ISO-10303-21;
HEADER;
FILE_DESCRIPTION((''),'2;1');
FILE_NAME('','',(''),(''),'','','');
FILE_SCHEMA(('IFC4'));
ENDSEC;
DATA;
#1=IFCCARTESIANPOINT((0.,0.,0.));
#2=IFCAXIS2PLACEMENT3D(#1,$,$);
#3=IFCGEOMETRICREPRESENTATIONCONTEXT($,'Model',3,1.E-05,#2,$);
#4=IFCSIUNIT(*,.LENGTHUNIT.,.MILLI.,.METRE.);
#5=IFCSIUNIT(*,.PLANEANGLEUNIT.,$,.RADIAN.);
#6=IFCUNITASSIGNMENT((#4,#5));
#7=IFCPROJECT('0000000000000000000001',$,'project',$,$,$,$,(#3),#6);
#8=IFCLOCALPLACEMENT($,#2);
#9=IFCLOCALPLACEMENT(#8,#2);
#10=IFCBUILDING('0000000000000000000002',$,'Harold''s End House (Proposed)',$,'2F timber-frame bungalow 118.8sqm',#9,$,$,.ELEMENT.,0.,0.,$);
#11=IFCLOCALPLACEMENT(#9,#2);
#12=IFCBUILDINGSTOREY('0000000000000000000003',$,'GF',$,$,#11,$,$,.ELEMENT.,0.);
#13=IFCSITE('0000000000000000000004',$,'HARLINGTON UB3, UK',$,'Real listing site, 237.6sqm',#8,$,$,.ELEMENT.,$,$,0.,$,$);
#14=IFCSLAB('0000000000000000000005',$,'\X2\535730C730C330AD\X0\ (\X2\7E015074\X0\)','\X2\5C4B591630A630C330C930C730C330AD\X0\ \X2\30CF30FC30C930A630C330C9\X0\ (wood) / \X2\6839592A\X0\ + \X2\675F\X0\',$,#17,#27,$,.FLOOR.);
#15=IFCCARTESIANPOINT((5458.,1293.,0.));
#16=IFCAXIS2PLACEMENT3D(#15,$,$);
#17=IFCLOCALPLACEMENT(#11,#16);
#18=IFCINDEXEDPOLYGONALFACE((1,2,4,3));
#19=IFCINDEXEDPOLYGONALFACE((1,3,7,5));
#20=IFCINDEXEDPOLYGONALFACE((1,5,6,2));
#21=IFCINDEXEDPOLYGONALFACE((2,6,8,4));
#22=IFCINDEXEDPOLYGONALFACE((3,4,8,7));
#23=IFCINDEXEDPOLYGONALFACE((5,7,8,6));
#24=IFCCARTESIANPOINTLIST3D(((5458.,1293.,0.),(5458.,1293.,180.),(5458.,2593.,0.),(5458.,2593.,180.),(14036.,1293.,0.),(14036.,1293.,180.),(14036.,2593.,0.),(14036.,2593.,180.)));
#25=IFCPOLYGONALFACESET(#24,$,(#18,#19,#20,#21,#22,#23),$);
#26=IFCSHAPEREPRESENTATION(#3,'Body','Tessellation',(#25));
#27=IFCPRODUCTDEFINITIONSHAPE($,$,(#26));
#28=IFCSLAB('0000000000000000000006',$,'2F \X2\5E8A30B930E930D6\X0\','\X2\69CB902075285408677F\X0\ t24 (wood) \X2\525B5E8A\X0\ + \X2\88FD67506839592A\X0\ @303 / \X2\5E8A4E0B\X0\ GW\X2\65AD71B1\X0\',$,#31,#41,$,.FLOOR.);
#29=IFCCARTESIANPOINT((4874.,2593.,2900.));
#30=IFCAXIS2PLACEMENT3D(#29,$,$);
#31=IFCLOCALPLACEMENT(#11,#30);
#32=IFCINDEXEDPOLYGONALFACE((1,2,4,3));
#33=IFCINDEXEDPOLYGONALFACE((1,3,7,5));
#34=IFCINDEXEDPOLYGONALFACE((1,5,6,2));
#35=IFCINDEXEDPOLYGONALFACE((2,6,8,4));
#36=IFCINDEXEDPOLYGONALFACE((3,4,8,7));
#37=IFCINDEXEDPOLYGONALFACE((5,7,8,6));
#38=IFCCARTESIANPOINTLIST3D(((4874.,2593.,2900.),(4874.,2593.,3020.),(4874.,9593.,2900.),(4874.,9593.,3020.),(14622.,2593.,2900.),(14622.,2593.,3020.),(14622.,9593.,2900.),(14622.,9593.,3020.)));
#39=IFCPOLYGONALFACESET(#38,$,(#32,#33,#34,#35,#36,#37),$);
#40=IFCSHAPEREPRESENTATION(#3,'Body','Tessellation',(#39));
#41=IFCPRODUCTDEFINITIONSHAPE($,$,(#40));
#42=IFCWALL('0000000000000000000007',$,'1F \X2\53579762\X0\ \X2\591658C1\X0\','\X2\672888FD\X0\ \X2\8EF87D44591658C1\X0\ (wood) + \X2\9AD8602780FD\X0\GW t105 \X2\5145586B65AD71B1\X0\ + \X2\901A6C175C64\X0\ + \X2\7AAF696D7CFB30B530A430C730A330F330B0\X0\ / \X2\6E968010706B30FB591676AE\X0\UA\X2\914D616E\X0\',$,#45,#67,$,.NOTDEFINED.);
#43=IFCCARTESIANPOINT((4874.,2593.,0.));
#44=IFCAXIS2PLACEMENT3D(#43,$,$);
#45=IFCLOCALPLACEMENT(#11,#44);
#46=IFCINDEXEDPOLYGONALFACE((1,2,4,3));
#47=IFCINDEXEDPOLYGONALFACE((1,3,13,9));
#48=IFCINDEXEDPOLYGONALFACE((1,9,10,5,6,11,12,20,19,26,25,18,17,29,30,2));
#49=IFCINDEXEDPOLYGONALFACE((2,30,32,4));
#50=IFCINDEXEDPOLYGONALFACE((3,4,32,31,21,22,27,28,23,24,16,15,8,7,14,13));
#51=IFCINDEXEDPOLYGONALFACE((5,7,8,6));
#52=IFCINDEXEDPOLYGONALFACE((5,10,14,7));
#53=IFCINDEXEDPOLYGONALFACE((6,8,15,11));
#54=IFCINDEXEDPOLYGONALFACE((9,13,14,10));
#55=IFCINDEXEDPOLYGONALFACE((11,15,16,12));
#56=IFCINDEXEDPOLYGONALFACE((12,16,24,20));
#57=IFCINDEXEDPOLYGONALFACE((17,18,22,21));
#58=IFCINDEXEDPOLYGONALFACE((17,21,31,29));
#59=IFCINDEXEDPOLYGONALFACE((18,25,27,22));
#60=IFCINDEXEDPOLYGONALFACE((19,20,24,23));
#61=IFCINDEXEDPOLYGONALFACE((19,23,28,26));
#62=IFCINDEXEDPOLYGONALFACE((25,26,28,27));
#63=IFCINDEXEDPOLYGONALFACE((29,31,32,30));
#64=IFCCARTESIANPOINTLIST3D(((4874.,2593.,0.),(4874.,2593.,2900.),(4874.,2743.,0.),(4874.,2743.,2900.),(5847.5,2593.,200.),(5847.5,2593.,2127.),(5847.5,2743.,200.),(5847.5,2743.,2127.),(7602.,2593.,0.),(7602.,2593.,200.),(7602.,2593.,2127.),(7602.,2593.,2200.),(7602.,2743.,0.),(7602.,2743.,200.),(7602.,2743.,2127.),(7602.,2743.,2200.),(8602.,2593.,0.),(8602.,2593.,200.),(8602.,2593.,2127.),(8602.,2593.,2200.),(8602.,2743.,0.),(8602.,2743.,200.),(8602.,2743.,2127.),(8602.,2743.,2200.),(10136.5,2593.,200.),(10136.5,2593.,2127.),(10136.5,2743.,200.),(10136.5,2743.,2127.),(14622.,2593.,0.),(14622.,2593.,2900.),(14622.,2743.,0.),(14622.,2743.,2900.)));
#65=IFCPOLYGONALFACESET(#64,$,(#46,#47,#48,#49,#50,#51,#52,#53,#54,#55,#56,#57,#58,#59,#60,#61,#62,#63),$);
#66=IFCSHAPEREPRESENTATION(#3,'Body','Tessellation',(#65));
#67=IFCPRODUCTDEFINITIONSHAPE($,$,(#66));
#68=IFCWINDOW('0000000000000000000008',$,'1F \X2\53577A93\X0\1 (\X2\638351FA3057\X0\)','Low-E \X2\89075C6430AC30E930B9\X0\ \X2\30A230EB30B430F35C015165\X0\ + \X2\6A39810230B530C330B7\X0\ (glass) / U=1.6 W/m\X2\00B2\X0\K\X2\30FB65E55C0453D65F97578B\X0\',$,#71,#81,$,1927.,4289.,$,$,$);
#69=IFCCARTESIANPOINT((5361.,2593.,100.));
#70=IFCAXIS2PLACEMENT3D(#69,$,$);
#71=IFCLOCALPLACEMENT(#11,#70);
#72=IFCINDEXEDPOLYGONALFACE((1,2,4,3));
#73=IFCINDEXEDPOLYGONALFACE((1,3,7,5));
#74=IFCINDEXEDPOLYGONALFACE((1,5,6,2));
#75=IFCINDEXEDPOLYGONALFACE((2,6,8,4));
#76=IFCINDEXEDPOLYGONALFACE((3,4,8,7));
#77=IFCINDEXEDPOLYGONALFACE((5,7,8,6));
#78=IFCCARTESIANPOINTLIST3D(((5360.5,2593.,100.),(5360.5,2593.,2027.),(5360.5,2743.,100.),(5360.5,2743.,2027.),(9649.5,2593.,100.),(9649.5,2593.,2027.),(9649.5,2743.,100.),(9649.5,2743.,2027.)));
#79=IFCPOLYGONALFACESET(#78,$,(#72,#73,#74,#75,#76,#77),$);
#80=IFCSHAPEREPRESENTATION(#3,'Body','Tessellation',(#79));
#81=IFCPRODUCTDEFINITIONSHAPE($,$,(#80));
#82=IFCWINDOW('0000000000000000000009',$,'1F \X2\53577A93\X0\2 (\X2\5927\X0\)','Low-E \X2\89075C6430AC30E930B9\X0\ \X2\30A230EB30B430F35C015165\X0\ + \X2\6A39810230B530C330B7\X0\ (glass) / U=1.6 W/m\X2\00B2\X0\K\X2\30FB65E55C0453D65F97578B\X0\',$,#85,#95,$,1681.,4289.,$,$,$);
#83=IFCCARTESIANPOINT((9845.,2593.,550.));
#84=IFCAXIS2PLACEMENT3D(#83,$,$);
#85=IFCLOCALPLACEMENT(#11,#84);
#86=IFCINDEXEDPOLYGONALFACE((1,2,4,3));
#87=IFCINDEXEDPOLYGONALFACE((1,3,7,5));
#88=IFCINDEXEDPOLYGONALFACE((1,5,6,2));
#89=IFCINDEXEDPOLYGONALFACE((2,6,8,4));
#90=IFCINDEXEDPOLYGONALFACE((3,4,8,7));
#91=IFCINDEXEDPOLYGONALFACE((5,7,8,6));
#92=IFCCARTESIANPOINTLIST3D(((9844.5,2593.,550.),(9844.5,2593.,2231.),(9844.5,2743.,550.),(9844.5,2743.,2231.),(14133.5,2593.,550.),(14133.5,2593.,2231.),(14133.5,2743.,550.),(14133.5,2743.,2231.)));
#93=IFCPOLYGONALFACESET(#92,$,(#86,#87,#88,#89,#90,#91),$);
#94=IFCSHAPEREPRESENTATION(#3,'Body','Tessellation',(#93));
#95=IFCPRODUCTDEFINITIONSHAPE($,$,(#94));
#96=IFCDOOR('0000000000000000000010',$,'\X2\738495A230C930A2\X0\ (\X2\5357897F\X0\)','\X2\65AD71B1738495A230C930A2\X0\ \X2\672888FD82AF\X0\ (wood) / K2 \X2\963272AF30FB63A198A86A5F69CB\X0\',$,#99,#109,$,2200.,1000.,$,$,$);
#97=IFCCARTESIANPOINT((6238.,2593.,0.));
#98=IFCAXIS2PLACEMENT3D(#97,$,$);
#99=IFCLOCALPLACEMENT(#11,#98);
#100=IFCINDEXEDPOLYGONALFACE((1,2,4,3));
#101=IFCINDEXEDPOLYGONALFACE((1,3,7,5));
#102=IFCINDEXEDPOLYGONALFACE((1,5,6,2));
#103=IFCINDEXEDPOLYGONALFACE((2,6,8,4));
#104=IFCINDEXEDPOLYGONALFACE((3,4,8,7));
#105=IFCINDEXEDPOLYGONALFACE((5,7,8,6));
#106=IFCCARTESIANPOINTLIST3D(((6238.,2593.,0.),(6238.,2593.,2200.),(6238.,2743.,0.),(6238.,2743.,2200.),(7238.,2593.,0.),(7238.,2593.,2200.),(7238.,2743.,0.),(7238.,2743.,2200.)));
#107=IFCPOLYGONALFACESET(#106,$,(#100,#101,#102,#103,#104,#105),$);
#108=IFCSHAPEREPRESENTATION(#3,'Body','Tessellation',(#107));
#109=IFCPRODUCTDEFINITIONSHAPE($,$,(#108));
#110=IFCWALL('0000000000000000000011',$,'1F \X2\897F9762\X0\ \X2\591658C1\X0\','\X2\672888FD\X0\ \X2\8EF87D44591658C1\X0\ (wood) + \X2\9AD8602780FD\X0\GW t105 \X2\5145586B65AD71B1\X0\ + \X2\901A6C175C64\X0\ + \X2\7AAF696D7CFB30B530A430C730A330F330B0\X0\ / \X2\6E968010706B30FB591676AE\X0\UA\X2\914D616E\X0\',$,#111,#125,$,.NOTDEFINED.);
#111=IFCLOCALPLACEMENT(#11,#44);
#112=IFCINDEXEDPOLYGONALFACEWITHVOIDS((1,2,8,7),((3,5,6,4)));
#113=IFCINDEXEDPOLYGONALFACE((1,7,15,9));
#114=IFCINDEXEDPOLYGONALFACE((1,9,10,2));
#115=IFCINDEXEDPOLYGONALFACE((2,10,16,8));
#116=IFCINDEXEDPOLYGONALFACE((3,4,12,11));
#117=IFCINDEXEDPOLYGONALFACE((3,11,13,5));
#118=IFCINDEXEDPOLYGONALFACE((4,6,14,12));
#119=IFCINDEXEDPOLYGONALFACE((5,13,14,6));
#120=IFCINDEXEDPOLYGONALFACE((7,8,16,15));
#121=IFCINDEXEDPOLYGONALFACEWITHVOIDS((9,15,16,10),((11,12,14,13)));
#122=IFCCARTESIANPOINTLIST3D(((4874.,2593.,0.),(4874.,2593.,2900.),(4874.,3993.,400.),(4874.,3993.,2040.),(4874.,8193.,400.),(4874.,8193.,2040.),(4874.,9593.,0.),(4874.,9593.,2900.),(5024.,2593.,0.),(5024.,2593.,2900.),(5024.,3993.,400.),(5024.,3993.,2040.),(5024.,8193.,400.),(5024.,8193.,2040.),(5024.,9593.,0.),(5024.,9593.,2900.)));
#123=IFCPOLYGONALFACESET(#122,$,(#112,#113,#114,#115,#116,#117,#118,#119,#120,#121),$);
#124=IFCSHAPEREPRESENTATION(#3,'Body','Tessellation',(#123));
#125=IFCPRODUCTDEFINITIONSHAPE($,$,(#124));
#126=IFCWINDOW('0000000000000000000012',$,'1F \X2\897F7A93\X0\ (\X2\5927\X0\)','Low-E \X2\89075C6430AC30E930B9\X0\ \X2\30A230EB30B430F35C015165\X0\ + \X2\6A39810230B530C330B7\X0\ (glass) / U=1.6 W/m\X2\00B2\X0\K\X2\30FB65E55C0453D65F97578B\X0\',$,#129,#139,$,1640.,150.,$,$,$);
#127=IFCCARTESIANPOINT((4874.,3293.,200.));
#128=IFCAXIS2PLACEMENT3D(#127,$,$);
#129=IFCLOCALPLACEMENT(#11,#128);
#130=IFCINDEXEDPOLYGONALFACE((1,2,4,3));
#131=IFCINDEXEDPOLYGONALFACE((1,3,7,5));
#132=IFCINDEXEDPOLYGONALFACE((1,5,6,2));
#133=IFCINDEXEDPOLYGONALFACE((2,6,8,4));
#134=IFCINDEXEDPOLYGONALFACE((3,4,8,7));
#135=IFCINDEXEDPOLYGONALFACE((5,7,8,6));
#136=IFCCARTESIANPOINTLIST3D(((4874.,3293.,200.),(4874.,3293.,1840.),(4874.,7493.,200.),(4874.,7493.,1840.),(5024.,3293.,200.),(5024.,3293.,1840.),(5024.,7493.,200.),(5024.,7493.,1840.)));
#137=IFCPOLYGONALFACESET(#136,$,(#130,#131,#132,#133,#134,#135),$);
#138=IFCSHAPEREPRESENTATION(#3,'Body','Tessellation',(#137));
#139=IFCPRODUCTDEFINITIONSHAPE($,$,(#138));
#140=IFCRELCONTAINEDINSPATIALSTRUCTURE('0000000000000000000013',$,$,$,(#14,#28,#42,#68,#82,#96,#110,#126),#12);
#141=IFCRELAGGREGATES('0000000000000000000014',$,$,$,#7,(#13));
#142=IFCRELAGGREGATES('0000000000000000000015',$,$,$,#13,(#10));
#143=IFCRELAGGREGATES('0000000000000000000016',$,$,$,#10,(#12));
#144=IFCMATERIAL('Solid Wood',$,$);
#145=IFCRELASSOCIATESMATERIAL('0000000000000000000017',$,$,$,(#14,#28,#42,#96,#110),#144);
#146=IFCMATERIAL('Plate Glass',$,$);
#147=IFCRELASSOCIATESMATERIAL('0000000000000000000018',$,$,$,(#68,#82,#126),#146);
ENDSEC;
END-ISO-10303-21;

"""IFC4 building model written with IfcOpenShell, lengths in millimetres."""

from ifc_helpers import new_model, si_unit, frame, frame_2d, origin, place, context, project, spatial, rectangle, extrude, material, element, fill, save


model = new_model("IFC4")

# Units and contexts
model_context = context("Model", 3, precision=1e-05, world=origin())
ifc_project = project(units=[si_unit("LENGTHUNIT", "METRE", prefix="MILLI"), si_unit("PLANEANGLEUNIT", "RADIAN")], contexts=[model_context])

# Site, building, storey
site_placement = place(None, origin())
site = spatial("IfcSite", under=ifc_project, at=site_placement, Name="HARLINGTON UB3, UK", ObjectType="Real listing site, 237.6sqm", CompositionType="ELEMENT", RefElevation=0.0)
building_placement = place(site_placement, origin())
building = spatial("IfcBuilding", under=site, at=building_placement, Name="Harold's End House (Proposed)", ObjectType="2F timber-frame bungalow 118.8sqm", CompositionType="ELEMENT", ElevationOfRefHeight=0.0, ElevationOfTerrain=0.0)
storey_placement = place(building_placement, origin())
storey = spatial("IfcBuildingStorey", under=building, at=storey_placement, Name="GF", CompositionType="ELEMENT", Elevation=0.0)

# Slabs
ifc_material_1 = material(Name="Solid Wood")
slab_1_placement = place(storey_placement, frame((5458.0, 1293.0, 0.0)))
element("IfcSlab", 1, at=slab_1_placement, inside=storey, material=ifc_material_1, Name="南デッキ (縁側)", Description="屋外ウッドデッキ ハードウッド (wood) / 根太 + 束", PredefinedType="FLOOR", context=model_context, shape_type="SweptSolid", body=[
    extrude(rectangle(XDim=8578.0, YDim=1300.0, at=frame_2d((4289.0, 650.0))), frame((5458.0, 1293.0, 0.0)), (0.0, 0.0, 1.0), 180.0),
])
slab_2_placement = place(storey_placement, frame((4874.0, 2593.0, 2900.0)))
element("IfcSlab", 2, at=slab_2_placement, inside=storey, material=ifc_material_1, Name="2F 床スラブ", Description="構造用合板 t24 (wood) 剛床 + 製材根太 @303 / 床下 GW断熱", PredefinedType="FLOOR", context=model_context, shape_type="SweptSolid", body=[
    extrude(rectangle(XDim=9748.0, YDim=7000.0, at=frame_2d((4874.0, 3500.0))), frame((4874.0, 2593.0, 2900.0)), (0.0, 0.0, 1.0), 120.0),
])

# Wall, openings, windows, door
wall_1_placement = place(storey_placement, frame((4874.0, 2593.0, 0.0)))
wall_1 = element("IfcWall", 3, at=wall_1_placement, inside=storey, material=ifc_material_1, Name="1F 南面 外壁", Description="木製 軸組外壁 (wood) + 高性能GW t105 充填断熱 + 通気層 + 窯業系サイディング / 準耐火・外皮UA配慮", PredefinedType="NOTDEFINED", context=model_context, shape_type="SweptSolid", body=[
    extrude(rectangle(XDim=9748.0, YDim=150.0, at=frame_2d((4874.0, 75.0))), frame((4874.0, 2593.0, 0.0)), (0.0, 0.0, 1.0), 2900.0),
])
opening_1_placement = place(storey_placement, frame((5361.0, 2593.0, 100.0)))
opening_1 = element("IfcOpeningElement", 4, at=opening_1_placement, cuts=wall_1, PredefinedType="NOTDEFINED", context=model_context, shape_type="SweptSolid", body=[
    extrude(rectangle(XDim=4289.0, YDim=150.0, at=frame_2d((2144.0, 75.0))), frame((5361.0, 2593.0, 100.0)), (0.0, 0.0, 1.0), 1927.0),
])
opening_2_placement = place(storey_placement, frame((9845.0, 2593.0, 550.0)))
opening_2 = element("IfcOpeningElement", 5, at=opening_2_placement, cuts=wall_1, PredefinedType="NOTDEFINED", context=model_context, shape_type="SweptSolid", body=[
    extrude(rectangle(XDim=4289.0, YDim=150.0, at=frame_2d((2144.0, 75.0))), frame((9845.0, 2593.0, 550.0)), (0.0, 0.0, 1.0), 1681.0),
])
opening_3_placement = place(storey_placement, frame((6238.0, 2593.0, 0.0)))
opening_3 = element("IfcOpeningElement", 6, at=opening_3_placement, cuts=wall_1, PredefinedType="NOTDEFINED", context=model_context, shape_type="SweptSolid", body=[
    extrude(rectangle(XDim=1000.0, YDim=150.0, at=frame_2d((500.0, 75.0))), frame((6238.0, 2593.0, 0.0)), (0.0, 0.0, 1.0), 2200.0),
])
ifc_material_2 = material(Name="Plate Glass")
window_1_placement = place(storey_placement, frame((5361.0, 2593.0, 100.0)))
window_1 = element("IfcWindow", 7, at=window_1_placement, inside=storey, material=ifc_material_2, Name="1F 南窓1 (掃出し)", Description="Low-E 複層ガラス アルゴン封入 + 樹脂サッシ (glass) / U=1.6 W/m²K・日射取得型", OverallHeight=1927.0, OverallWidth=4289.0, context=model_context, shape_type="SweptSolid", body=[
    extrude(rectangle(XDim=4289.0, YDim=150.0, at=frame_2d((2144.0, 75.0))), frame((5361.0, 2593.0, 100.0)), (0.0, 0.0, 1.0), 1927.0),
])
fill(opening_1, window_1)
window_2_placement = place(storey_placement, frame((9845.0, 2593.0, 550.0)))
window_2 = element("IfcWindow", 8, at=window_2_placement, inside=storey, material=ifc_material_2, Name="1F 南窓2 (大)", Description="Low-E 複層ガラス アルゴン封入 + 樹脂サッシ (glass) / U=1.6 W/m²K・日射取得型", OverallHeight=1681.0, OverallWidth=4289.0, context=model_context, shape_type="SweptSolid", body=[
    extrude(rectangle(XDim=4289.0, YDim=150.0, at=frame_2d((2144.0, 75.0))), frame((9845.0, 2593.0, 550.0)), (0.0, 0.0, 1.0), 1681.0),
])
fill(opening_2, window_2)
door_placement = place(storey_placement, frame((6238.0, 2593.0, 0.0)))
door = element("IfcDoor", 9, at=door_placement, inside=storey, material=ifc_material_1, Name="玄関ドア (南西)", Description="断熱玄関ドア 木製芯 (wood) / K2 防犯・採風機構", OverallHeight=2200.0, OverallWidth=1000.0, context=model_context, shape_type="SweptSolid", body=[
    extrude(rectangle(XDim=1000.0, YDim=150.0, at=frame_2d((500.0, 75.0))), frame((6238.0, 2593.0, 0.0)), (0.0, 0.0, 1.0), 2200.0),
])
fill(opening_3, door)

# Wall, opening, window
wall_2_placement = place(storey_placement, frame((4874.0, 2593.0, 0.0)))
wall_2 = element("IfcWall", 10, at=wall_2_placement, inside=storey, material=ifc_material_1, Name="1F 西面 外壁", Description="木製 軸組外壁 (wood) + 高性能GW t105 充填断熱 + 通気層 + 窯業系サイディング / 準耐火・外皮UA配慮", PredefinedType="NOTDEFINED", context=model_context, shape_type="SweptSolid", body=[
    extrude(rectangle(XDim=150.0, YDim=7000.0, at=frame_2d((75.0, 3500.0))), frame((4874.0, 2593.0, 0.0)), (0.0, 0.0, 1.0), 2900.0),
])
opening_4_placement = place(storey_placement, frame((4874.0, 3293.0, 200.0)))
opening_4 = element("IfcOpeningElement", 11, at=opening_4_placement, cuts=wall_2, PredefinedType="NOTDEFINED", context=model_context, shape_type="SweptSolid", body=[
    extrude(rectangle(XDim=150.0, YDim=4200.0, at=frame_2d((75.0, 2100.0))), frame((4874.0, 3293.0, 200.0)), (0.0, 0.0, 1.0), 1640.0),
])
window_3_placement = place(storey_placement, frame((4874.0, 3293.0, 200.0)))
window_3 = element("IfcWindow", 12, at=window_3_placement, inside=storey, material=ifc_material_2, Name="1F 西窓 (大)", Description="Low-E 複層ガラス アルゴン封入 + 樹脂サッシ (glass) / U=1.6 W/m²K・日射取得型", OverallHeight=1640.0, OverallWidth=150.0, context=model_context, shape_type="SweptSolid", body=[
    extrude(rectangle(XDim=150.0, YDim=4200.0, at=frame_2d((75.0, 2100.0))), frame((4874.0, 3293.0, 200.0)), (0.0, 0.0, 1.0), 1640.0),
])
fill(opening_4, window_3)

save(model, "model.ifc")
